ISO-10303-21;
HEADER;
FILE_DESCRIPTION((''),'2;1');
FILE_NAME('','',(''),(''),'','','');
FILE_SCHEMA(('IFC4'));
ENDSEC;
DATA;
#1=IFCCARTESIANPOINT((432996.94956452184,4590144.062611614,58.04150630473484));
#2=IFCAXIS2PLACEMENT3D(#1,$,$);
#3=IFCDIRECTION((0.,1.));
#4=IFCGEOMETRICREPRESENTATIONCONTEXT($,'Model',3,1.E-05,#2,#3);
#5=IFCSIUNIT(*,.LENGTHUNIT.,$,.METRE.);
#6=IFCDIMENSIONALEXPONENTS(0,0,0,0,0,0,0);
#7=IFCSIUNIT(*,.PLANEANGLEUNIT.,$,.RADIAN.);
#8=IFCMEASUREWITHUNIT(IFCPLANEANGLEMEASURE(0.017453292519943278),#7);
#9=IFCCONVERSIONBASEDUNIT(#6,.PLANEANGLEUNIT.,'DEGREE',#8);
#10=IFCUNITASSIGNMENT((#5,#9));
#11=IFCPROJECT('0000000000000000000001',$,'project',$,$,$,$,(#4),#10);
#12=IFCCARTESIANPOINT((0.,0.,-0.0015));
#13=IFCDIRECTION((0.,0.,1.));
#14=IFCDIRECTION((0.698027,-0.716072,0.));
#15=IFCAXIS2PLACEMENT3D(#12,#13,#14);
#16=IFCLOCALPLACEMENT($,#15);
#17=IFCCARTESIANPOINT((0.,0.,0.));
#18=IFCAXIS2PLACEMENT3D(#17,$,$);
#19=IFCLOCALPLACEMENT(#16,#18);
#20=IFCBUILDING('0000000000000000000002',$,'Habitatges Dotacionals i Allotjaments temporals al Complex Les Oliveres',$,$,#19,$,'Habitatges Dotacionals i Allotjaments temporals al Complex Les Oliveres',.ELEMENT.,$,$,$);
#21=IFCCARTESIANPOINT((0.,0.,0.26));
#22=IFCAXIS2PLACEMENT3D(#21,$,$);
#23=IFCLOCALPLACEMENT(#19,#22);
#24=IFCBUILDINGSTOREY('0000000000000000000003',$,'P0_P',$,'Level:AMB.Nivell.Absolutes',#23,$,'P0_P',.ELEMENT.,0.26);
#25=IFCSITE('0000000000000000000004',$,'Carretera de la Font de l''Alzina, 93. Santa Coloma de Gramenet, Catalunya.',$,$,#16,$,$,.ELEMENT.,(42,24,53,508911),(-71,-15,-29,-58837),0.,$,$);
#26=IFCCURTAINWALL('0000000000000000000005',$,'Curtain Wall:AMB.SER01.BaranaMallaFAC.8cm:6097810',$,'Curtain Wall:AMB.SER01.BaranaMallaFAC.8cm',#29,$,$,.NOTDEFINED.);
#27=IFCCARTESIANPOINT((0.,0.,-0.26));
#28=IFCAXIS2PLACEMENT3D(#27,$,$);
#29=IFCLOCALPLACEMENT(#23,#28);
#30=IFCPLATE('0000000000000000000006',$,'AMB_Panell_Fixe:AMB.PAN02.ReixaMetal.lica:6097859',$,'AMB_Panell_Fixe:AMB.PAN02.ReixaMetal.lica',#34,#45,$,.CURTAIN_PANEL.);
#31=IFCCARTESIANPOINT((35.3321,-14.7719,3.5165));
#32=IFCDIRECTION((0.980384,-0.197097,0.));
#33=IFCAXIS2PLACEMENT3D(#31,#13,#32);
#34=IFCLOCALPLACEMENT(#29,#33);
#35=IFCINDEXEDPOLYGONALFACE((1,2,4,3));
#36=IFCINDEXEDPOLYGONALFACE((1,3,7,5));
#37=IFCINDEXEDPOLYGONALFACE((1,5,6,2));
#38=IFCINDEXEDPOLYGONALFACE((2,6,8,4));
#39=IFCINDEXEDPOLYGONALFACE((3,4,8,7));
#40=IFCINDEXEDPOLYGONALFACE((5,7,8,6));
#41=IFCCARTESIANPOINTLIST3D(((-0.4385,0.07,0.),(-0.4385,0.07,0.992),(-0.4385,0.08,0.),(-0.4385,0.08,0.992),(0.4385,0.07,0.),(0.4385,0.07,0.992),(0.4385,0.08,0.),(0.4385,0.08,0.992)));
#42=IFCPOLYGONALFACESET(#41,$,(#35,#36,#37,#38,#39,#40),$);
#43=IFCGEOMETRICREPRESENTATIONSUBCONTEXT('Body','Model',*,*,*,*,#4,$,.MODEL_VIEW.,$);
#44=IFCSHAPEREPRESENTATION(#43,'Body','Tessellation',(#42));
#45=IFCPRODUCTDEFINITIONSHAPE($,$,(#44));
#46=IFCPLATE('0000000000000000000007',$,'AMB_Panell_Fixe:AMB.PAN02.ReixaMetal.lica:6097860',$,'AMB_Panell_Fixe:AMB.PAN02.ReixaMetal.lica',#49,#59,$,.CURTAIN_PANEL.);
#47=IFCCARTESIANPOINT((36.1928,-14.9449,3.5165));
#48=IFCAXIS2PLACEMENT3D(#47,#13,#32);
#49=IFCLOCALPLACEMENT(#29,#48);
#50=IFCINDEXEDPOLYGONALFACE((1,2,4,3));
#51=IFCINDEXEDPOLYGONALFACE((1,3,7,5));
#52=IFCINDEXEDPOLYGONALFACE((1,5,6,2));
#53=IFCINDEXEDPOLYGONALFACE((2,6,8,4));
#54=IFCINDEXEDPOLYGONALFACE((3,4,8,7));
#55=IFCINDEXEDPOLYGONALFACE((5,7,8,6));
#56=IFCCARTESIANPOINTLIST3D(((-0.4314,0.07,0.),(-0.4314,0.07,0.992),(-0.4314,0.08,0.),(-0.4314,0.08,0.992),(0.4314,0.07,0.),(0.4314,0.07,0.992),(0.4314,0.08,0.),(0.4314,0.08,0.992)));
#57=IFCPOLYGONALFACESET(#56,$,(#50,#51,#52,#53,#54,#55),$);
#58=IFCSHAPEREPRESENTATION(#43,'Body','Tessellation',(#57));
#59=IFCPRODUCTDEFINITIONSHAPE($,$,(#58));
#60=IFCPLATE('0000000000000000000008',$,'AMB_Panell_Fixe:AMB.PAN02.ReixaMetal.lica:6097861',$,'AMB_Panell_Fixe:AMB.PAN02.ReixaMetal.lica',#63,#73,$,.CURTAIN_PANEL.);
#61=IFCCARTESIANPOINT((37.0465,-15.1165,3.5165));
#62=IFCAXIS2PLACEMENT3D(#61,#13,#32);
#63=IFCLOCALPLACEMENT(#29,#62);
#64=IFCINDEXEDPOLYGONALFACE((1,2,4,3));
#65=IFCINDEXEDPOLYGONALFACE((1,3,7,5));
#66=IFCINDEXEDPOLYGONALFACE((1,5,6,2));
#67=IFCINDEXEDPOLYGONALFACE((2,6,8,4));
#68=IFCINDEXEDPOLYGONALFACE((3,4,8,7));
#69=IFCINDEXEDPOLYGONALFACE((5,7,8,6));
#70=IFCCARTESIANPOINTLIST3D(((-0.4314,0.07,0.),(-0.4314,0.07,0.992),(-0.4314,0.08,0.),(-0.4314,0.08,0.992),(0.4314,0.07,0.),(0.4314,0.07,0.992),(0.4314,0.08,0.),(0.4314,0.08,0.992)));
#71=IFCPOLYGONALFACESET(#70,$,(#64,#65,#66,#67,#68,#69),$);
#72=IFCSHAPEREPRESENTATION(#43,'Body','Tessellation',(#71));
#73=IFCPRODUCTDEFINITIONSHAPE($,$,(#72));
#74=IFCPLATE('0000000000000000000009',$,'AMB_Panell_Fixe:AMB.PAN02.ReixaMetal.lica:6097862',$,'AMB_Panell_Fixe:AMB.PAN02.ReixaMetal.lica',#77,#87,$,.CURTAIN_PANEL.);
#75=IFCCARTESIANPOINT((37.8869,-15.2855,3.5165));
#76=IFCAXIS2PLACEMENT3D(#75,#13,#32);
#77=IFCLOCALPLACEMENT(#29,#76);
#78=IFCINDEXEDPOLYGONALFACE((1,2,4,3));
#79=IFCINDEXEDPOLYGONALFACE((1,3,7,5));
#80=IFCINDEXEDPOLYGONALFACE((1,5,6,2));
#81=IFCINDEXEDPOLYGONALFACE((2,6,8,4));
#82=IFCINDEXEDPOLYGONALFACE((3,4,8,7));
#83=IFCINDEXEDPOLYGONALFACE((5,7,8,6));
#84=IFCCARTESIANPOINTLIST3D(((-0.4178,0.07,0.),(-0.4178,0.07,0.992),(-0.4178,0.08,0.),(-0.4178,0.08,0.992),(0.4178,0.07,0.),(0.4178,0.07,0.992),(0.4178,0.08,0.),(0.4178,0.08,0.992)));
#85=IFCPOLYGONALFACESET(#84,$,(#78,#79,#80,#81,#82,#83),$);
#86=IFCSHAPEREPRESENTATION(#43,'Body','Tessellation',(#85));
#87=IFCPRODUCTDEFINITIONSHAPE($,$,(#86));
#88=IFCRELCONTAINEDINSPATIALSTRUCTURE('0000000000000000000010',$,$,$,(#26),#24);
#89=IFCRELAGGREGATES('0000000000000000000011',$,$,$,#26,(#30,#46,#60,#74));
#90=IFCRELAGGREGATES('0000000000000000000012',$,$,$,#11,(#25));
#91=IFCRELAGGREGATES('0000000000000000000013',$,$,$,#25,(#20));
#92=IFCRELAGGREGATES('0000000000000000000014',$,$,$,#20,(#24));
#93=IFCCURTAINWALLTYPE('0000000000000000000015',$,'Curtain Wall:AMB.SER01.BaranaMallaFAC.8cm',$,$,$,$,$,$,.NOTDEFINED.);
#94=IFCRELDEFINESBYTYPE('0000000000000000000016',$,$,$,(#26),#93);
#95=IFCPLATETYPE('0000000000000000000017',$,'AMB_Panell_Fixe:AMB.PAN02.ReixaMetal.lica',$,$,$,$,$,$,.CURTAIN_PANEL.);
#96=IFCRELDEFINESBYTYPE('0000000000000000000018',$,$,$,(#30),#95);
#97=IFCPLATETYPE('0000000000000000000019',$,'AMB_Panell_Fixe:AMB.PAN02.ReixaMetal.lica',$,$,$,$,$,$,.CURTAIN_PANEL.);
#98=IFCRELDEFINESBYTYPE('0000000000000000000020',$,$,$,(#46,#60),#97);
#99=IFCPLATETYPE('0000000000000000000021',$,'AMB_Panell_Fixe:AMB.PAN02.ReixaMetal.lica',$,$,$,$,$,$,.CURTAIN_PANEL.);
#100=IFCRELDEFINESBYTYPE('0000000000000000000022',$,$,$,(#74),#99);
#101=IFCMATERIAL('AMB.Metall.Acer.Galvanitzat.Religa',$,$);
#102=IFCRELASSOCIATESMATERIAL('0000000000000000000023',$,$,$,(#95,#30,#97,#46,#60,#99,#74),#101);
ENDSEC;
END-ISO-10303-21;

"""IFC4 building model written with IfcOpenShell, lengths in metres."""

from ifc_helpers import new_model, entity, si_unit, converted_unit, direction, frame, origin, place, context, subcontext, project, spatial, indexed_curve, outline, extrude, source, transform, mapped, material, type_object, type_shapes, element, aggregate, save


model = new_model("IFC4")

# Units and contexts
model_context = context("Model", 3, precision=1e-05, world=frame((432996.94956452184, 4590144.062611614, 58.04150630473484)), true_north=direction((0.0, 1.0)))
body_context = subcontext(model_context, "Body", "Model", "MODEL_VIEW")
ifc_project = project(units=[si_unit("LENGTHUNIT", "METRE"), converted_unit("PLANEANGLEUNIT", "DEGREE", entity("IfcPlaneAngleMeasure", 0.017453292519943278), si_unit("PLANEANGLEUNIT", "RADIAN"), dimensions=[0, 0, 0, 0, 0, 0, 0])], contexts=[model_context])

# Site, building, storey
site_placement = place(None, frame((0.0, 0.0, -0.0015), z_axis=(0.0, 0.0, 1.0), x_axis=(0.698027, -0.716072, 0.0)))
site = spatial("IfcSite", under=ifc_project, at=site_placement, Name="Carretera de la Font de l'Alzina, 93. Santa Coloma de Gramenet, Catalunya.", CompositionType="ELEMENT", RefLatitude=(42, 24, 53, 508911), RefLongitude=(-71, -15, -29, -58837), RefElevation=0.0)
building_placement = place(site_placement, origin())
building = spatial("IfcBuilding", under=site, at=building_placement, Name="Habitatges Dotacionals i Allotjaments temporals al Complex Les Oliveres", LongName="Habitatges Dotacionals i Allotjaments temporals al Complex Les Oliveres", CompositionType="ELEMENT")
storey_placement = place(building_placement, frame((0.0, 0.0, 0.26)))
storey = spatial("IfcBuildingStorey", under=building, at=storey_placement, Name="P0_P", ObjectType="Level:AMB.Nivell.Absolutes", LongName="P0_P", CompositionType="ELEMENT", Elevation=0.26)

# Curtain wall, plates
curtain_wall_type = type_object("IfcCurtainWallType", Name="Curtain Wall:AMB.SER01.BaranaMallaFAC.8cm", PredefinedType="NOTDEFINED")
curtain_wall_placement = place(storey_placement, frame((0.0, 0.0, -0.26)))
curtain_wall = element("IfcCurtainWall", 1, at=curtain_wall_placement, inside=storey, type_object=curtain_wall_type, Name="Curtain Wall:AMB.SER01.BaranaMallaFAC.8cm:6097810", ObjectType="Curtain Wall:AMB.SER01.BaranaMallaFAC.8cm", PredefinedType="NOTDEFINED")
ifc_material_1 = material(Name="AMB.Metall.Acer.Galvanitzat.Religa")
plate_type_1 = type_object("IfcPlateType", Name="AMB_Panell_Fixe:AMB.PAN02.ReixaMetal.lica", PredefinedType="CURTAIN_PANEL", material=ifc_material_1)
shared_shape_1 = source(origin(), body_context, "Body", "SweptSolid", [
    extrude(outline(indexed_curve([(-0.005, -0.4385), (0.005, -0.4385), (0.005, 0.4385), (-0.005, 0.4385), (-0.005, -0.4385)], self_intersect=False)), frame((0.0, 0.075, 0.0), z_axis=(0.0, 0.0, 1.0), x_axis=(0.0, 1.0, 0.0)), (0.0, 0.0, 1.0), 0.992),
])
type_shapes(plate_type_1, [shared_shape_1])
plate_1_placement = place(curtain_wall_placement, frame((35.3321, -14.7719, 3.5165), z_axis=(0.0, 0.0, 1.0), x_axis=(0.980384, -0.197097, 0.0)))
plate_1 = element("IfcPlate", 2, at=plate_1_placement, type_object=plate_type_1, material=ifc_material_1, Name="AMB_Panell_Fixe:AMB.PAN02.ReixaMetal.lica:6097859", ObjectType="AMB_Panell_Fixe:AMB.PAN02.ReixaMetal.lica", PredefinedType="CURTAIN_PANEL", context=body_context, shape_type="MappedRepresentation", body=[
    mapped(shared_shape_1, transform((0.0, 0.0, 0.0), scale=1.0)),
])
plate_type_2 = type_object("IfcPlateType", Name="AMB_Panell_Fixe:AMB.PAN02.ReixaMetal.lica", PredefinedType="CURTAIN_PANEL", material=ifc_material_1)
shared_shape_2 = source(origin(), body_context, "Body", "SweptSolid", [
    extrude(outline(indexed_curve([(-0.005, -0.4314), (0.005, -0.4314), (0.005, 0.4314), (-0.005, 0.4314), (-0.005, -0.4314)], self_intersect=False)), frame((0.0, 0.075, 0.0), z_axis=(0.0, 0.0, 1.0), x_axis=(0.0, 1.0, 0.0)), (0.0, 0.0, 1.0), 0.992),
])
type_shapes(plate_type_2, [shared_shape_2])
plate_2_placement = place(curtain_wall_placement, frame((36.1928, -14.9449, 3.5165), z_axis=(0.0, 0.0, 1.0), x_axis=(0.980384, -0.197097, 0.0)))
plate_2 = element("IfcPlate", 3, at=plate_2_placement, type_object=plate_type_2, material=ifc_material_1, Name="AMB_Panell_Fixe:AMB.PAN02.ReixaMetal.lica:6097860", ObjectType="AMB_Panell_Fixe:AMB.PAN02.ReixaMetal.lica", PredefinedType="CURTAIN_PANEL", context=body_context, shape_type="MappedRepresentation", body=[
    mapped(shared_shape_2, transform((0.0, 0.0, 0.0), scale=1.0)),
])
plate_3_placement = place(curtain_wall_placement, frame((37.0465, -15.1165, 3.5165), z_axis=(0.0, 0.0, 1.0), x_axis=(0.980384, -0.197097, 0.0)))
plate_3 = element("IfcPlate", 4, at=plate_3_placement, type_object=plate_type_2, material=ifc_material_1, Name="AMB_Panell_Fixe:AMB.PAN02.ReixaMetal.lica:6097861", ObjectType="AMB_Panell_Fixe:AMB.PAN02.ReixaMetal.lica", PredefinedType="CURTAIN_PANEL", context=body_context, shape_type="MappedRepresentation", body=[
    mapped(shared_shape_2, transform((0.0, 0.0, 0.0), scale=1.0)),
])
plate_type_3 = type_object("IfcPlateType", Name="AMB_Panell_Fixe:AMB.PAN02.ReixaMetal.lica", PredefinedType="CURTAIN_PANEL", material=ifc_material_1)
shared_shape_3 = source(origin(), body_context, "Body", "SweptSolid", [
    extrude(outline(indexed_curve([(-0.005, -0.4178), (0.005, -0.4178), (0.005, 0.4178), (-0.005, 0.4178), (-0.005, -0.4178)], self_intersect=False)), frame((0.0, 0.075, 0.0), z_axis=(0.0, 0.0, 1.0), x_axis=(0.0, 1.0, 0.0)), (0.0, 0.0, 1.0), 0.992),
])
type_shapes(plate_type_3, [shared_shape_3])
plate_4_placement = place(curtain_wall_placement, frame((37.8869, -15.2855, 3.5165), z_axis=(0.0, 0.0, 1.0), x_axis=(0.980384, -0.197097, 0.0)))
plate_4 = element("IfcPlate", 5, at=plate_4_placement, type_object=plate_type_3, material=ifc_material_1, Name="AMB_Panell_Fixe:AMB.PAN02.ReixaMetal.lica:6097862", ObjectType="AMB_Panell_Fixe:AMB.PAN02.ReixaMetal.lica", PredefinedType="CURTAIN_PANEL", context=body_context, shape_type="MappedRepresentation", body=[
    mapped(shared_shape_3, transform((0.0, 0.0, 0.0), scale=1.0)),
])
aggregate(curtain_wall, [plate_1, plate_2, plate_3, plate_4])

save(model, "model.ifc")
